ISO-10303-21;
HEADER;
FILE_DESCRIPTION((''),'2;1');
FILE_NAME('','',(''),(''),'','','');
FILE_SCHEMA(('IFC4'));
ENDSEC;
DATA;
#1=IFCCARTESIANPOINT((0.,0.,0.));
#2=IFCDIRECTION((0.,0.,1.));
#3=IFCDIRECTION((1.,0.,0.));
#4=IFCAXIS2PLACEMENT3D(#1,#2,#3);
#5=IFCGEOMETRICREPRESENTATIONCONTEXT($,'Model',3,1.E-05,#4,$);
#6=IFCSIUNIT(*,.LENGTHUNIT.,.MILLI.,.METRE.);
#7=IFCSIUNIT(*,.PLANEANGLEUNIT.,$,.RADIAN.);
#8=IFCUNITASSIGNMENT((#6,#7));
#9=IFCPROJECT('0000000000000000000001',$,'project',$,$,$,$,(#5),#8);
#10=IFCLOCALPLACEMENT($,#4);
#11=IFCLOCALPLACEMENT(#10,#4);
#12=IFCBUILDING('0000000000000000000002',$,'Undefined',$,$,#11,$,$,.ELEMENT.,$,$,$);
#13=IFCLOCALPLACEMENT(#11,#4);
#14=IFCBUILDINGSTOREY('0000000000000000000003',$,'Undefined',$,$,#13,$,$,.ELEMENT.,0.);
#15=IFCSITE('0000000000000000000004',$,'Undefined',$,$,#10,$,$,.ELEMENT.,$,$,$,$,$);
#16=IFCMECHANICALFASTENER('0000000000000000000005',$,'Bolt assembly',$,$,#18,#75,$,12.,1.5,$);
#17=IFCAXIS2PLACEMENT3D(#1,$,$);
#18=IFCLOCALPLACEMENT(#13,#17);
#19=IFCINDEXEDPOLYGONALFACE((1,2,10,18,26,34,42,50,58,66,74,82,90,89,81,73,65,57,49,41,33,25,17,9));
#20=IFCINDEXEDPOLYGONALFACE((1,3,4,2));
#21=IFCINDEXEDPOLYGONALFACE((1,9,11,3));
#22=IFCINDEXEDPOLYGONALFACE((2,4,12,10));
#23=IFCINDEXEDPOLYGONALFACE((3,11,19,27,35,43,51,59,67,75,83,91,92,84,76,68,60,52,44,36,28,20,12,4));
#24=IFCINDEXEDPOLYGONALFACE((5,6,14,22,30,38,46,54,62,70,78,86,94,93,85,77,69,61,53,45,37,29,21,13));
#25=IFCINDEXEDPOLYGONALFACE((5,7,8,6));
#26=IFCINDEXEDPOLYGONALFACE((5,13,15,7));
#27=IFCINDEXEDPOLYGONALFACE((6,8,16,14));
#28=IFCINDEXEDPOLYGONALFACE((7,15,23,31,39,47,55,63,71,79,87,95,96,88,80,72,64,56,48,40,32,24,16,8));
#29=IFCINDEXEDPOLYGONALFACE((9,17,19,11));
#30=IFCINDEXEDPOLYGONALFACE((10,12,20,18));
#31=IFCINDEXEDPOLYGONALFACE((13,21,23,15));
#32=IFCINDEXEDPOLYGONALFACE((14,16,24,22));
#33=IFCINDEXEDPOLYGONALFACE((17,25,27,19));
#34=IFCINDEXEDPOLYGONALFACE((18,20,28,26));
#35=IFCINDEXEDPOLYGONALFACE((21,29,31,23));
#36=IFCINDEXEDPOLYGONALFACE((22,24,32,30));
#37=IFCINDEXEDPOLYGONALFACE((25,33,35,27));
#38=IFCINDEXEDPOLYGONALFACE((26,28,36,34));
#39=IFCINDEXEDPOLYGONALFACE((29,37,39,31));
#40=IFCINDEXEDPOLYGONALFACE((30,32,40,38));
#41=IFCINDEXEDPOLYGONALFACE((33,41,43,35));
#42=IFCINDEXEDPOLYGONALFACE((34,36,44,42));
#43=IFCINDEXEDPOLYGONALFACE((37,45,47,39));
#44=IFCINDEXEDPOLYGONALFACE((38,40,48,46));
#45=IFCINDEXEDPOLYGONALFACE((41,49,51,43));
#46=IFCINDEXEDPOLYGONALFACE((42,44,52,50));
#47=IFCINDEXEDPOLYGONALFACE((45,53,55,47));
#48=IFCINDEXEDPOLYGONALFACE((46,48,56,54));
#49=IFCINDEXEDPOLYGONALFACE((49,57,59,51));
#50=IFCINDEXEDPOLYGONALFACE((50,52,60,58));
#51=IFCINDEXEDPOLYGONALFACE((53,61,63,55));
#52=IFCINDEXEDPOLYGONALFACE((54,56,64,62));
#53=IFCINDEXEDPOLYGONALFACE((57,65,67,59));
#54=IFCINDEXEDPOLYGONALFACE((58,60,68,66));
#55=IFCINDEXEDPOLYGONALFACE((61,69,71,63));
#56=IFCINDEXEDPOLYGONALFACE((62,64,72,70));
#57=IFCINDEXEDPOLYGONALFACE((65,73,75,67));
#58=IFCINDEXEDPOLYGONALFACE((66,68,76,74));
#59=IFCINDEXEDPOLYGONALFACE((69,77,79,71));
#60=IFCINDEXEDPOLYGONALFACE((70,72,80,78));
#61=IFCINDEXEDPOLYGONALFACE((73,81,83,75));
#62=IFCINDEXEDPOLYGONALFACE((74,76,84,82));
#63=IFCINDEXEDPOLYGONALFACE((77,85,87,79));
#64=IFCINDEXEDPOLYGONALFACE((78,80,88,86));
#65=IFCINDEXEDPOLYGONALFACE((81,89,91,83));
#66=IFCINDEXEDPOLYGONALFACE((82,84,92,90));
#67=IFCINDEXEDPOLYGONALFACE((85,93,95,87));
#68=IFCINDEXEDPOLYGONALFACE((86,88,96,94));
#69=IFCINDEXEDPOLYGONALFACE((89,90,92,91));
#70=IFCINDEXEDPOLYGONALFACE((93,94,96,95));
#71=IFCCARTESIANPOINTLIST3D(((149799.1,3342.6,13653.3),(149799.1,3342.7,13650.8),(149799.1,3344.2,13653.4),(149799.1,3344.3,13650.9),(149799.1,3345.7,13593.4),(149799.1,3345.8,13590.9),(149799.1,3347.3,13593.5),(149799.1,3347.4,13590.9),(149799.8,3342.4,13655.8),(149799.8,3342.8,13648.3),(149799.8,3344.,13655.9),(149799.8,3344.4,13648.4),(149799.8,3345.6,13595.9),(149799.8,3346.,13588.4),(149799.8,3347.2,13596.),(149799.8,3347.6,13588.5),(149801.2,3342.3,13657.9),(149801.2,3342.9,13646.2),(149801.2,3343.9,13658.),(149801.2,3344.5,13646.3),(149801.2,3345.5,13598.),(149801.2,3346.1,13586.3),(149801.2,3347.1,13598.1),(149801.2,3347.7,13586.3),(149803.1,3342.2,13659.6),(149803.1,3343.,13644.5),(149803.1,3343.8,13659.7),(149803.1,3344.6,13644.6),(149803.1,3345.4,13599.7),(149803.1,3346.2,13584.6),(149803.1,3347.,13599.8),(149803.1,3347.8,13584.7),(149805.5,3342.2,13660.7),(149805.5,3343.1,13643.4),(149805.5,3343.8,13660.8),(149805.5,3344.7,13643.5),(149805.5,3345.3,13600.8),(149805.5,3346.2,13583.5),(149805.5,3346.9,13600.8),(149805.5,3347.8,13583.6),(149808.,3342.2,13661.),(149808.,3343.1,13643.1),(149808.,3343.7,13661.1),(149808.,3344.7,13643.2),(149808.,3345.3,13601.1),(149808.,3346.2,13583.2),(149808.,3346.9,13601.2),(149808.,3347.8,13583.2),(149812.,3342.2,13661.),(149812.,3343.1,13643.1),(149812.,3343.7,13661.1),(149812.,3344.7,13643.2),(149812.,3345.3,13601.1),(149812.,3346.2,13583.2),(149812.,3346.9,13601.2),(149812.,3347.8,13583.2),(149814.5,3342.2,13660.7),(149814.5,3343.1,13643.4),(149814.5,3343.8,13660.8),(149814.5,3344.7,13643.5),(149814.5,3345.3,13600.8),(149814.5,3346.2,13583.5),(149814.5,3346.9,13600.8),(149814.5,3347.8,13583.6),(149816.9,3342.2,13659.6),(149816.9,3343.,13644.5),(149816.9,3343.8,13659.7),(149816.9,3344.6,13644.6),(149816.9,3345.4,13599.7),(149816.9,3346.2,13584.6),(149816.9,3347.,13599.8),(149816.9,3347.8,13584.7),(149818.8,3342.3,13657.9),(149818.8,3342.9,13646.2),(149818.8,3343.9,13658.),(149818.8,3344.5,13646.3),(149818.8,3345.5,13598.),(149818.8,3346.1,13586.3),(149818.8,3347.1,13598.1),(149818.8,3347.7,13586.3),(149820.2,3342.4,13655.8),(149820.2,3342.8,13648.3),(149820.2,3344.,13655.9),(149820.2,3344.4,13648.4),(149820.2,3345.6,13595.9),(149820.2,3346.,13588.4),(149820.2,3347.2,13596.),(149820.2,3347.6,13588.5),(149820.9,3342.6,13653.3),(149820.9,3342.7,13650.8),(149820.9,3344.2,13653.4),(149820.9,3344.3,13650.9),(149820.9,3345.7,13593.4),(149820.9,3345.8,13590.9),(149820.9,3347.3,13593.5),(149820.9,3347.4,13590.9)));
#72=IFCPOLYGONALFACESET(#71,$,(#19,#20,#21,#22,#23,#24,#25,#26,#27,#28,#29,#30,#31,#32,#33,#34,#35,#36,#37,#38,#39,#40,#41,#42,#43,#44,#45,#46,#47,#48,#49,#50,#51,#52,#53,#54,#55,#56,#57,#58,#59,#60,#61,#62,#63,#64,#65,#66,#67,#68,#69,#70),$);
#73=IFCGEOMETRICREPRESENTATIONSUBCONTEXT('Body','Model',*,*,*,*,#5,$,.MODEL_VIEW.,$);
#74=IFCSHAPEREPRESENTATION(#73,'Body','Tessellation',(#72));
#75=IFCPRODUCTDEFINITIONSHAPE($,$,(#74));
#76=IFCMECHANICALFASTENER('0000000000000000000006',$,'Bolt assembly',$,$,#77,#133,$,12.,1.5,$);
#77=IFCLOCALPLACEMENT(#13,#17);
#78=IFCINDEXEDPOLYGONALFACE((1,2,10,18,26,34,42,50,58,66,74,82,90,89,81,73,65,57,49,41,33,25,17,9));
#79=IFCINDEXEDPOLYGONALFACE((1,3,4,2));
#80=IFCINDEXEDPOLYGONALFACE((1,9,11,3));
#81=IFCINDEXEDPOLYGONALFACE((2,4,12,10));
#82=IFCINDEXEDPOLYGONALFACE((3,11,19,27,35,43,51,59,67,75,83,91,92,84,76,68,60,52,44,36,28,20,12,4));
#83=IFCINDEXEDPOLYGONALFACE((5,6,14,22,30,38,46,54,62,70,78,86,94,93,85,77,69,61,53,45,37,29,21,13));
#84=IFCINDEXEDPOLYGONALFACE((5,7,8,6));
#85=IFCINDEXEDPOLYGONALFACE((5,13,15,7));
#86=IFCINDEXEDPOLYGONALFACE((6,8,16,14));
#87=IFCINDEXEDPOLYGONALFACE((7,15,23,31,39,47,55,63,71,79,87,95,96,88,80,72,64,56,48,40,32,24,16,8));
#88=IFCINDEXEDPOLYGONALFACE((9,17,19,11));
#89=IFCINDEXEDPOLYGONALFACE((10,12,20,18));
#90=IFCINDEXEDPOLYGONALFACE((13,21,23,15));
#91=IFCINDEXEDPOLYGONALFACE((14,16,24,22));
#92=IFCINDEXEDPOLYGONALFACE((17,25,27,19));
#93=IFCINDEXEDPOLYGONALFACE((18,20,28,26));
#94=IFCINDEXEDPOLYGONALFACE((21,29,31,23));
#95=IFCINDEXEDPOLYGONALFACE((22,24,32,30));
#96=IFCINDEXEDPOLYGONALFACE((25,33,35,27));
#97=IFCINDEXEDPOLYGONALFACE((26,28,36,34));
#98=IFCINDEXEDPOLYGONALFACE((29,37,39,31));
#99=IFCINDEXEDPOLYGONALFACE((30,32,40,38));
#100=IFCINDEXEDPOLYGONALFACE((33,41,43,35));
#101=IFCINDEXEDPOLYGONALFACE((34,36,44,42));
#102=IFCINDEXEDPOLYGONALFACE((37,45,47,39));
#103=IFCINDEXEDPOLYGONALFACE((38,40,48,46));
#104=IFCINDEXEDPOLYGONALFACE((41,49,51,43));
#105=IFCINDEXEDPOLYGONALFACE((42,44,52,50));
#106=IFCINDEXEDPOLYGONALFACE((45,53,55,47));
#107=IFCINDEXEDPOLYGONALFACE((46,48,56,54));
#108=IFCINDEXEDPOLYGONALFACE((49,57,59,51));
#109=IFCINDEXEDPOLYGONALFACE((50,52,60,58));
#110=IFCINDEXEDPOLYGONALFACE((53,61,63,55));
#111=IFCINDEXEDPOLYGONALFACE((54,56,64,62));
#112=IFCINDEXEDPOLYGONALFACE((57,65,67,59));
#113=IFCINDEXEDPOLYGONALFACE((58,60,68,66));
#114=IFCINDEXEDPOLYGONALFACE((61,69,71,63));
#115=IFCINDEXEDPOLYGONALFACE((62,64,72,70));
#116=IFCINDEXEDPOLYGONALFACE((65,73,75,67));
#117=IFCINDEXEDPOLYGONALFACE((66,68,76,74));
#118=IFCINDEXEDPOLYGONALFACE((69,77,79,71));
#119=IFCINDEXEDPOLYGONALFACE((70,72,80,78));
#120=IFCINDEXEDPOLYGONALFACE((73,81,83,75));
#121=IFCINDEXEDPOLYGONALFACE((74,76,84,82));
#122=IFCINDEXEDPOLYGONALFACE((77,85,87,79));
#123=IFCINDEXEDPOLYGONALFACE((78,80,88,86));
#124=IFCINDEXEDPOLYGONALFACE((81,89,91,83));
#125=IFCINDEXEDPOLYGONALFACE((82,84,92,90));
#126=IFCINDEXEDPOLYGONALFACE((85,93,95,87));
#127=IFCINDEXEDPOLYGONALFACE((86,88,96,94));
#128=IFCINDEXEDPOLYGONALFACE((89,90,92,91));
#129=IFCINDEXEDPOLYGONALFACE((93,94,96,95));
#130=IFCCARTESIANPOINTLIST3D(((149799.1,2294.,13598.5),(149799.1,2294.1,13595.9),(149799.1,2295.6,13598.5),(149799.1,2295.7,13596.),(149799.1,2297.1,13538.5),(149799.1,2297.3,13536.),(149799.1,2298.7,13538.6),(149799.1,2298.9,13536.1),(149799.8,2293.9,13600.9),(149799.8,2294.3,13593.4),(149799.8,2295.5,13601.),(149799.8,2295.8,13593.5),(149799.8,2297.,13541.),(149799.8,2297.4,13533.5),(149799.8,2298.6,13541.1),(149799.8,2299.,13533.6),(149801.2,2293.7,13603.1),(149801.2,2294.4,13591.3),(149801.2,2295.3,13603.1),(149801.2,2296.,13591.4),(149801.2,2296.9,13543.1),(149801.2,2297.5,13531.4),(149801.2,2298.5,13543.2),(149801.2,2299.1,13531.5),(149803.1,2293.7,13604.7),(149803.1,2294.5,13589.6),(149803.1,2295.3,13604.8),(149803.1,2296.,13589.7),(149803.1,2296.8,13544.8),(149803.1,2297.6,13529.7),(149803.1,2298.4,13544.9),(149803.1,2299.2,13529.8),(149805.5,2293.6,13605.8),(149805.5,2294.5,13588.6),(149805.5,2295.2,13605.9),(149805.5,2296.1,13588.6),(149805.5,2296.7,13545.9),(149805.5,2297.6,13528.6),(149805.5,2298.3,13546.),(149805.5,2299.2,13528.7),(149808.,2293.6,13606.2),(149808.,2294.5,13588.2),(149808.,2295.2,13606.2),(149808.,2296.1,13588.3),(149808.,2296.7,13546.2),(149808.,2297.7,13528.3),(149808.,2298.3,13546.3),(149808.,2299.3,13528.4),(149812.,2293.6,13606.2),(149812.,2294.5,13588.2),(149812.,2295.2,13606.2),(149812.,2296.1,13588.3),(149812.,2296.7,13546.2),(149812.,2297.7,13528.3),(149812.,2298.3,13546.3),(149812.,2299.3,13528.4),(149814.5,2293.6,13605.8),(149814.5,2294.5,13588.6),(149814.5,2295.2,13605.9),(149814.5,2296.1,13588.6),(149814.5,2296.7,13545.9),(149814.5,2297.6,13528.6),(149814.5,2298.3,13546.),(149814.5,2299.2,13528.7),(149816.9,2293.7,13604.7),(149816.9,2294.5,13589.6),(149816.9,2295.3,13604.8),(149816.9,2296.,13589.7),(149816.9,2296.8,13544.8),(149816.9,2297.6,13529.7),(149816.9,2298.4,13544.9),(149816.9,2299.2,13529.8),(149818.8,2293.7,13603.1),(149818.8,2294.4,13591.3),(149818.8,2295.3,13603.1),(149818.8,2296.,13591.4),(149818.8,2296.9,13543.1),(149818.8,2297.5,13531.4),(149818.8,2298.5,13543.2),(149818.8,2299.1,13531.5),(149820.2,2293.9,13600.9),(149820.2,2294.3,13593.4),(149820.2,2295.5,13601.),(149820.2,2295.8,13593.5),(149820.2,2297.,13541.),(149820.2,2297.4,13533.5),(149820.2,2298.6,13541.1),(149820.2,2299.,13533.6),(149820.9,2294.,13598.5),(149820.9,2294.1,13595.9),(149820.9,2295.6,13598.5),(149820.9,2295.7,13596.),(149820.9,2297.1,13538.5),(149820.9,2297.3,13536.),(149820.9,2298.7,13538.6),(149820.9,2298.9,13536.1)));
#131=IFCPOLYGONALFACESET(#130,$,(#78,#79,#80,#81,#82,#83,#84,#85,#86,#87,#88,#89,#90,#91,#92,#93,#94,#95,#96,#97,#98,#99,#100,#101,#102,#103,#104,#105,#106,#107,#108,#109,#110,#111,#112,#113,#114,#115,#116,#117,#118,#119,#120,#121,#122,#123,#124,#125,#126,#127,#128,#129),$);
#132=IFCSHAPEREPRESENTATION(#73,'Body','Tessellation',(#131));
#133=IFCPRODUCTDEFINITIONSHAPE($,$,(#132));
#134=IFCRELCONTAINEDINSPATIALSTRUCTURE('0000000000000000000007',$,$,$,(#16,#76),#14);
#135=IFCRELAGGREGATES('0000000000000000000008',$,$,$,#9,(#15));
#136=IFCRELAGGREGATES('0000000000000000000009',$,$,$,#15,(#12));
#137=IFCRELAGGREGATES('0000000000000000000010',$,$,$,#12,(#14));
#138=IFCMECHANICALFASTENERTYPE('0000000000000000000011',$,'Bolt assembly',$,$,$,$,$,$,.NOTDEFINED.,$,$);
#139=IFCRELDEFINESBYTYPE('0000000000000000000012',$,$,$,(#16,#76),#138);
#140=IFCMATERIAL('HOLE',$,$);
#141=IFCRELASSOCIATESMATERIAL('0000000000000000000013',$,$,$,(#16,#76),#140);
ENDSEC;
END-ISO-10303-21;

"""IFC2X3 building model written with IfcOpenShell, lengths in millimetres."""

from ifc_helpers import new_model, si_unit, frame, frame_2d, origin_with_axes, place, context, subcontext, project, spatial, polyline, circle_curve, parameter, trimmed, segment, composite_curve, outline, extrude, source, transform, mapped, material, type_object, element, save


model = new_model("IFC2X3")

# Units and contexts
model_context = context("Model", 3, precision=1e-05, world=origin_with_axes())
body_context = subcontext(model_context, "Body", "Model", "MODEL_VIEW")
ifc_project = project(units=[si_unit("LENGTHUNIT", "METRE", prefix="MILLI"), si_unit("PLANEANGLEUNIT", "RADIAN")], contexts=[model_context])

# Site, building, storey
site_placement = place(None, origin_with_axes())
site = spatial("IfcSite", under=ifc_project, at=site_placement, Name="Undefined", CompositionType="ELEMENT")
building_placement = place(site_placement, origin_with_axes())
building = spatial("IfcBuilding", under=site, at=building_placement, Name="Undefined", CompositionType="ELEMENT")
storey_placement = place(building_placement, origin_with_axes())
storey = spatial("IfcBuildingStorey", under=building, at=storey_placement, Name="Undefined", CompositionType="ELEMENT", Elevation=0.0)

# Mechanical fasteners
ifc_material_1 = material(Name="HOLE")
mechanical_fastener_type = type_object("IfcMechanicalFastenerType", Name="Bolt assembly")
shared_shape_1 = source(origin_with_axes(), body_context, "Body", "SweptSolid", [
    extrude(outline(composite_curve([segment(polyline([(9.0, 2.0), (9.0, -2.0)]), True, "CONTINUOUS"), segment(trimmed(circle_curve(frame_2d((0.0, -2.0), x_axis=(1.0, 0.0)), 9.0), [parameter(0.0)], [parameter(3.141593)], False, "PARAMETER"), True, "CONTINUOUS"), segment(polyline([(-9.0, -2.0), (-9.0, 2.0)]), True, "CONTINUOUS"), segment(trimmed(circle_curve(frame_2d((0.0, 2.0), x_axis=(-1.0, 0.0)), 9.0), [parameter(0.0)], [parameter(3.141593)], False, "PARAMETER"), True, "DISCONTINUOUS")], self_intersect=False)), frame((0.0, 0.0, 0.0), z_axis=(0.0, 1.0, 0.0), x_axis=(1.0, 0.0, 0.0)), (0.0, 0.0, 1.0), 1.6),
])
mechanical_fastener_1_placement = place(storey_placement, frame((149810.0, 3347.4, 13592.2), z_axis=(1.0, 0.0, 0.0), x_axis=(0.0, -0.052361, 0.998628)))
element("IfcMechanicalFastener", 1, at=mechanical_fastener_1_placement, inside=storey, type_object=mechanical_fastener_type, material=ifc_material_1, Name="Bolt assembly", NominalDiameter=12.0, NominalLength=1.5, context=body_context, shape_type="MappedRepresentation", body=[
    mapped(shared_shape_1, transform((0.0, 0.0, 0.0))),
    mapped(shared_shape_1, transform((60.0, 0.0, 0.0))),
])
shared_shape_2 = source(origin_with_axes(), body_context, "Body", "SweptSolid", [
    extrude(outline(composite_curve([segment(polyline([(9.0, 2.0), (9.0, -2.0)]), True, "CONTINUOUS"), segment(trimmed(circle_curve(frame_2d((0.0, -2.0), x_axis=(1.0, 0.0)), 9.0), [parameter(0.0)], [parameter(3.141593)], False, "PARAMETER"), True, "CONTINUOUS"), segment(polyline([(-9.0, -2.0), (-9.0, 2.0)]), True, "CONTINUOUS"), segment(trimmed(circle_curve(frame_2d((0.0, 2.0), x_axis=(-1.0, 0.0)), 9.0), [parameter(0.0)], [parameter(3.141593)], False, "PARAMETER"), True, "DISCONTINUOUS")], self_intersect=False)), frame((0.0, 0.0, 0.0), z_axis=(0.0, 1.0, 0.0), x_axis=(1.0, 0.0, 0.0)), (0.0, 0.0, 1.0), 1.6),
])
mechanical_fastener_2_placement = place(storey_placement, frame((149810.0, 2298.8, 13537.3), z_axis=(1.0, 0.0, 0.0), x_axis=(0.0, -0.052361, 0.998628)))
element("IfcMechanicalFastener", 2, at=mechanical_fastener_2_placement, inside=storey, type_object=mechanical_fastener_type, material=ifc_material_1, Name="Bolt assembly", NominalDiameter=12.0, NominalLength=1.5, context=body_context, shape_type="MappedRepresentation", body=[
    mapped(shared_shape_2, transform((0.0, 0.0, 0.0))),
    mapped(shared_shape_2, transform((60.0, 0.0, 0.0))),
])

save(model, "model.ifc")
